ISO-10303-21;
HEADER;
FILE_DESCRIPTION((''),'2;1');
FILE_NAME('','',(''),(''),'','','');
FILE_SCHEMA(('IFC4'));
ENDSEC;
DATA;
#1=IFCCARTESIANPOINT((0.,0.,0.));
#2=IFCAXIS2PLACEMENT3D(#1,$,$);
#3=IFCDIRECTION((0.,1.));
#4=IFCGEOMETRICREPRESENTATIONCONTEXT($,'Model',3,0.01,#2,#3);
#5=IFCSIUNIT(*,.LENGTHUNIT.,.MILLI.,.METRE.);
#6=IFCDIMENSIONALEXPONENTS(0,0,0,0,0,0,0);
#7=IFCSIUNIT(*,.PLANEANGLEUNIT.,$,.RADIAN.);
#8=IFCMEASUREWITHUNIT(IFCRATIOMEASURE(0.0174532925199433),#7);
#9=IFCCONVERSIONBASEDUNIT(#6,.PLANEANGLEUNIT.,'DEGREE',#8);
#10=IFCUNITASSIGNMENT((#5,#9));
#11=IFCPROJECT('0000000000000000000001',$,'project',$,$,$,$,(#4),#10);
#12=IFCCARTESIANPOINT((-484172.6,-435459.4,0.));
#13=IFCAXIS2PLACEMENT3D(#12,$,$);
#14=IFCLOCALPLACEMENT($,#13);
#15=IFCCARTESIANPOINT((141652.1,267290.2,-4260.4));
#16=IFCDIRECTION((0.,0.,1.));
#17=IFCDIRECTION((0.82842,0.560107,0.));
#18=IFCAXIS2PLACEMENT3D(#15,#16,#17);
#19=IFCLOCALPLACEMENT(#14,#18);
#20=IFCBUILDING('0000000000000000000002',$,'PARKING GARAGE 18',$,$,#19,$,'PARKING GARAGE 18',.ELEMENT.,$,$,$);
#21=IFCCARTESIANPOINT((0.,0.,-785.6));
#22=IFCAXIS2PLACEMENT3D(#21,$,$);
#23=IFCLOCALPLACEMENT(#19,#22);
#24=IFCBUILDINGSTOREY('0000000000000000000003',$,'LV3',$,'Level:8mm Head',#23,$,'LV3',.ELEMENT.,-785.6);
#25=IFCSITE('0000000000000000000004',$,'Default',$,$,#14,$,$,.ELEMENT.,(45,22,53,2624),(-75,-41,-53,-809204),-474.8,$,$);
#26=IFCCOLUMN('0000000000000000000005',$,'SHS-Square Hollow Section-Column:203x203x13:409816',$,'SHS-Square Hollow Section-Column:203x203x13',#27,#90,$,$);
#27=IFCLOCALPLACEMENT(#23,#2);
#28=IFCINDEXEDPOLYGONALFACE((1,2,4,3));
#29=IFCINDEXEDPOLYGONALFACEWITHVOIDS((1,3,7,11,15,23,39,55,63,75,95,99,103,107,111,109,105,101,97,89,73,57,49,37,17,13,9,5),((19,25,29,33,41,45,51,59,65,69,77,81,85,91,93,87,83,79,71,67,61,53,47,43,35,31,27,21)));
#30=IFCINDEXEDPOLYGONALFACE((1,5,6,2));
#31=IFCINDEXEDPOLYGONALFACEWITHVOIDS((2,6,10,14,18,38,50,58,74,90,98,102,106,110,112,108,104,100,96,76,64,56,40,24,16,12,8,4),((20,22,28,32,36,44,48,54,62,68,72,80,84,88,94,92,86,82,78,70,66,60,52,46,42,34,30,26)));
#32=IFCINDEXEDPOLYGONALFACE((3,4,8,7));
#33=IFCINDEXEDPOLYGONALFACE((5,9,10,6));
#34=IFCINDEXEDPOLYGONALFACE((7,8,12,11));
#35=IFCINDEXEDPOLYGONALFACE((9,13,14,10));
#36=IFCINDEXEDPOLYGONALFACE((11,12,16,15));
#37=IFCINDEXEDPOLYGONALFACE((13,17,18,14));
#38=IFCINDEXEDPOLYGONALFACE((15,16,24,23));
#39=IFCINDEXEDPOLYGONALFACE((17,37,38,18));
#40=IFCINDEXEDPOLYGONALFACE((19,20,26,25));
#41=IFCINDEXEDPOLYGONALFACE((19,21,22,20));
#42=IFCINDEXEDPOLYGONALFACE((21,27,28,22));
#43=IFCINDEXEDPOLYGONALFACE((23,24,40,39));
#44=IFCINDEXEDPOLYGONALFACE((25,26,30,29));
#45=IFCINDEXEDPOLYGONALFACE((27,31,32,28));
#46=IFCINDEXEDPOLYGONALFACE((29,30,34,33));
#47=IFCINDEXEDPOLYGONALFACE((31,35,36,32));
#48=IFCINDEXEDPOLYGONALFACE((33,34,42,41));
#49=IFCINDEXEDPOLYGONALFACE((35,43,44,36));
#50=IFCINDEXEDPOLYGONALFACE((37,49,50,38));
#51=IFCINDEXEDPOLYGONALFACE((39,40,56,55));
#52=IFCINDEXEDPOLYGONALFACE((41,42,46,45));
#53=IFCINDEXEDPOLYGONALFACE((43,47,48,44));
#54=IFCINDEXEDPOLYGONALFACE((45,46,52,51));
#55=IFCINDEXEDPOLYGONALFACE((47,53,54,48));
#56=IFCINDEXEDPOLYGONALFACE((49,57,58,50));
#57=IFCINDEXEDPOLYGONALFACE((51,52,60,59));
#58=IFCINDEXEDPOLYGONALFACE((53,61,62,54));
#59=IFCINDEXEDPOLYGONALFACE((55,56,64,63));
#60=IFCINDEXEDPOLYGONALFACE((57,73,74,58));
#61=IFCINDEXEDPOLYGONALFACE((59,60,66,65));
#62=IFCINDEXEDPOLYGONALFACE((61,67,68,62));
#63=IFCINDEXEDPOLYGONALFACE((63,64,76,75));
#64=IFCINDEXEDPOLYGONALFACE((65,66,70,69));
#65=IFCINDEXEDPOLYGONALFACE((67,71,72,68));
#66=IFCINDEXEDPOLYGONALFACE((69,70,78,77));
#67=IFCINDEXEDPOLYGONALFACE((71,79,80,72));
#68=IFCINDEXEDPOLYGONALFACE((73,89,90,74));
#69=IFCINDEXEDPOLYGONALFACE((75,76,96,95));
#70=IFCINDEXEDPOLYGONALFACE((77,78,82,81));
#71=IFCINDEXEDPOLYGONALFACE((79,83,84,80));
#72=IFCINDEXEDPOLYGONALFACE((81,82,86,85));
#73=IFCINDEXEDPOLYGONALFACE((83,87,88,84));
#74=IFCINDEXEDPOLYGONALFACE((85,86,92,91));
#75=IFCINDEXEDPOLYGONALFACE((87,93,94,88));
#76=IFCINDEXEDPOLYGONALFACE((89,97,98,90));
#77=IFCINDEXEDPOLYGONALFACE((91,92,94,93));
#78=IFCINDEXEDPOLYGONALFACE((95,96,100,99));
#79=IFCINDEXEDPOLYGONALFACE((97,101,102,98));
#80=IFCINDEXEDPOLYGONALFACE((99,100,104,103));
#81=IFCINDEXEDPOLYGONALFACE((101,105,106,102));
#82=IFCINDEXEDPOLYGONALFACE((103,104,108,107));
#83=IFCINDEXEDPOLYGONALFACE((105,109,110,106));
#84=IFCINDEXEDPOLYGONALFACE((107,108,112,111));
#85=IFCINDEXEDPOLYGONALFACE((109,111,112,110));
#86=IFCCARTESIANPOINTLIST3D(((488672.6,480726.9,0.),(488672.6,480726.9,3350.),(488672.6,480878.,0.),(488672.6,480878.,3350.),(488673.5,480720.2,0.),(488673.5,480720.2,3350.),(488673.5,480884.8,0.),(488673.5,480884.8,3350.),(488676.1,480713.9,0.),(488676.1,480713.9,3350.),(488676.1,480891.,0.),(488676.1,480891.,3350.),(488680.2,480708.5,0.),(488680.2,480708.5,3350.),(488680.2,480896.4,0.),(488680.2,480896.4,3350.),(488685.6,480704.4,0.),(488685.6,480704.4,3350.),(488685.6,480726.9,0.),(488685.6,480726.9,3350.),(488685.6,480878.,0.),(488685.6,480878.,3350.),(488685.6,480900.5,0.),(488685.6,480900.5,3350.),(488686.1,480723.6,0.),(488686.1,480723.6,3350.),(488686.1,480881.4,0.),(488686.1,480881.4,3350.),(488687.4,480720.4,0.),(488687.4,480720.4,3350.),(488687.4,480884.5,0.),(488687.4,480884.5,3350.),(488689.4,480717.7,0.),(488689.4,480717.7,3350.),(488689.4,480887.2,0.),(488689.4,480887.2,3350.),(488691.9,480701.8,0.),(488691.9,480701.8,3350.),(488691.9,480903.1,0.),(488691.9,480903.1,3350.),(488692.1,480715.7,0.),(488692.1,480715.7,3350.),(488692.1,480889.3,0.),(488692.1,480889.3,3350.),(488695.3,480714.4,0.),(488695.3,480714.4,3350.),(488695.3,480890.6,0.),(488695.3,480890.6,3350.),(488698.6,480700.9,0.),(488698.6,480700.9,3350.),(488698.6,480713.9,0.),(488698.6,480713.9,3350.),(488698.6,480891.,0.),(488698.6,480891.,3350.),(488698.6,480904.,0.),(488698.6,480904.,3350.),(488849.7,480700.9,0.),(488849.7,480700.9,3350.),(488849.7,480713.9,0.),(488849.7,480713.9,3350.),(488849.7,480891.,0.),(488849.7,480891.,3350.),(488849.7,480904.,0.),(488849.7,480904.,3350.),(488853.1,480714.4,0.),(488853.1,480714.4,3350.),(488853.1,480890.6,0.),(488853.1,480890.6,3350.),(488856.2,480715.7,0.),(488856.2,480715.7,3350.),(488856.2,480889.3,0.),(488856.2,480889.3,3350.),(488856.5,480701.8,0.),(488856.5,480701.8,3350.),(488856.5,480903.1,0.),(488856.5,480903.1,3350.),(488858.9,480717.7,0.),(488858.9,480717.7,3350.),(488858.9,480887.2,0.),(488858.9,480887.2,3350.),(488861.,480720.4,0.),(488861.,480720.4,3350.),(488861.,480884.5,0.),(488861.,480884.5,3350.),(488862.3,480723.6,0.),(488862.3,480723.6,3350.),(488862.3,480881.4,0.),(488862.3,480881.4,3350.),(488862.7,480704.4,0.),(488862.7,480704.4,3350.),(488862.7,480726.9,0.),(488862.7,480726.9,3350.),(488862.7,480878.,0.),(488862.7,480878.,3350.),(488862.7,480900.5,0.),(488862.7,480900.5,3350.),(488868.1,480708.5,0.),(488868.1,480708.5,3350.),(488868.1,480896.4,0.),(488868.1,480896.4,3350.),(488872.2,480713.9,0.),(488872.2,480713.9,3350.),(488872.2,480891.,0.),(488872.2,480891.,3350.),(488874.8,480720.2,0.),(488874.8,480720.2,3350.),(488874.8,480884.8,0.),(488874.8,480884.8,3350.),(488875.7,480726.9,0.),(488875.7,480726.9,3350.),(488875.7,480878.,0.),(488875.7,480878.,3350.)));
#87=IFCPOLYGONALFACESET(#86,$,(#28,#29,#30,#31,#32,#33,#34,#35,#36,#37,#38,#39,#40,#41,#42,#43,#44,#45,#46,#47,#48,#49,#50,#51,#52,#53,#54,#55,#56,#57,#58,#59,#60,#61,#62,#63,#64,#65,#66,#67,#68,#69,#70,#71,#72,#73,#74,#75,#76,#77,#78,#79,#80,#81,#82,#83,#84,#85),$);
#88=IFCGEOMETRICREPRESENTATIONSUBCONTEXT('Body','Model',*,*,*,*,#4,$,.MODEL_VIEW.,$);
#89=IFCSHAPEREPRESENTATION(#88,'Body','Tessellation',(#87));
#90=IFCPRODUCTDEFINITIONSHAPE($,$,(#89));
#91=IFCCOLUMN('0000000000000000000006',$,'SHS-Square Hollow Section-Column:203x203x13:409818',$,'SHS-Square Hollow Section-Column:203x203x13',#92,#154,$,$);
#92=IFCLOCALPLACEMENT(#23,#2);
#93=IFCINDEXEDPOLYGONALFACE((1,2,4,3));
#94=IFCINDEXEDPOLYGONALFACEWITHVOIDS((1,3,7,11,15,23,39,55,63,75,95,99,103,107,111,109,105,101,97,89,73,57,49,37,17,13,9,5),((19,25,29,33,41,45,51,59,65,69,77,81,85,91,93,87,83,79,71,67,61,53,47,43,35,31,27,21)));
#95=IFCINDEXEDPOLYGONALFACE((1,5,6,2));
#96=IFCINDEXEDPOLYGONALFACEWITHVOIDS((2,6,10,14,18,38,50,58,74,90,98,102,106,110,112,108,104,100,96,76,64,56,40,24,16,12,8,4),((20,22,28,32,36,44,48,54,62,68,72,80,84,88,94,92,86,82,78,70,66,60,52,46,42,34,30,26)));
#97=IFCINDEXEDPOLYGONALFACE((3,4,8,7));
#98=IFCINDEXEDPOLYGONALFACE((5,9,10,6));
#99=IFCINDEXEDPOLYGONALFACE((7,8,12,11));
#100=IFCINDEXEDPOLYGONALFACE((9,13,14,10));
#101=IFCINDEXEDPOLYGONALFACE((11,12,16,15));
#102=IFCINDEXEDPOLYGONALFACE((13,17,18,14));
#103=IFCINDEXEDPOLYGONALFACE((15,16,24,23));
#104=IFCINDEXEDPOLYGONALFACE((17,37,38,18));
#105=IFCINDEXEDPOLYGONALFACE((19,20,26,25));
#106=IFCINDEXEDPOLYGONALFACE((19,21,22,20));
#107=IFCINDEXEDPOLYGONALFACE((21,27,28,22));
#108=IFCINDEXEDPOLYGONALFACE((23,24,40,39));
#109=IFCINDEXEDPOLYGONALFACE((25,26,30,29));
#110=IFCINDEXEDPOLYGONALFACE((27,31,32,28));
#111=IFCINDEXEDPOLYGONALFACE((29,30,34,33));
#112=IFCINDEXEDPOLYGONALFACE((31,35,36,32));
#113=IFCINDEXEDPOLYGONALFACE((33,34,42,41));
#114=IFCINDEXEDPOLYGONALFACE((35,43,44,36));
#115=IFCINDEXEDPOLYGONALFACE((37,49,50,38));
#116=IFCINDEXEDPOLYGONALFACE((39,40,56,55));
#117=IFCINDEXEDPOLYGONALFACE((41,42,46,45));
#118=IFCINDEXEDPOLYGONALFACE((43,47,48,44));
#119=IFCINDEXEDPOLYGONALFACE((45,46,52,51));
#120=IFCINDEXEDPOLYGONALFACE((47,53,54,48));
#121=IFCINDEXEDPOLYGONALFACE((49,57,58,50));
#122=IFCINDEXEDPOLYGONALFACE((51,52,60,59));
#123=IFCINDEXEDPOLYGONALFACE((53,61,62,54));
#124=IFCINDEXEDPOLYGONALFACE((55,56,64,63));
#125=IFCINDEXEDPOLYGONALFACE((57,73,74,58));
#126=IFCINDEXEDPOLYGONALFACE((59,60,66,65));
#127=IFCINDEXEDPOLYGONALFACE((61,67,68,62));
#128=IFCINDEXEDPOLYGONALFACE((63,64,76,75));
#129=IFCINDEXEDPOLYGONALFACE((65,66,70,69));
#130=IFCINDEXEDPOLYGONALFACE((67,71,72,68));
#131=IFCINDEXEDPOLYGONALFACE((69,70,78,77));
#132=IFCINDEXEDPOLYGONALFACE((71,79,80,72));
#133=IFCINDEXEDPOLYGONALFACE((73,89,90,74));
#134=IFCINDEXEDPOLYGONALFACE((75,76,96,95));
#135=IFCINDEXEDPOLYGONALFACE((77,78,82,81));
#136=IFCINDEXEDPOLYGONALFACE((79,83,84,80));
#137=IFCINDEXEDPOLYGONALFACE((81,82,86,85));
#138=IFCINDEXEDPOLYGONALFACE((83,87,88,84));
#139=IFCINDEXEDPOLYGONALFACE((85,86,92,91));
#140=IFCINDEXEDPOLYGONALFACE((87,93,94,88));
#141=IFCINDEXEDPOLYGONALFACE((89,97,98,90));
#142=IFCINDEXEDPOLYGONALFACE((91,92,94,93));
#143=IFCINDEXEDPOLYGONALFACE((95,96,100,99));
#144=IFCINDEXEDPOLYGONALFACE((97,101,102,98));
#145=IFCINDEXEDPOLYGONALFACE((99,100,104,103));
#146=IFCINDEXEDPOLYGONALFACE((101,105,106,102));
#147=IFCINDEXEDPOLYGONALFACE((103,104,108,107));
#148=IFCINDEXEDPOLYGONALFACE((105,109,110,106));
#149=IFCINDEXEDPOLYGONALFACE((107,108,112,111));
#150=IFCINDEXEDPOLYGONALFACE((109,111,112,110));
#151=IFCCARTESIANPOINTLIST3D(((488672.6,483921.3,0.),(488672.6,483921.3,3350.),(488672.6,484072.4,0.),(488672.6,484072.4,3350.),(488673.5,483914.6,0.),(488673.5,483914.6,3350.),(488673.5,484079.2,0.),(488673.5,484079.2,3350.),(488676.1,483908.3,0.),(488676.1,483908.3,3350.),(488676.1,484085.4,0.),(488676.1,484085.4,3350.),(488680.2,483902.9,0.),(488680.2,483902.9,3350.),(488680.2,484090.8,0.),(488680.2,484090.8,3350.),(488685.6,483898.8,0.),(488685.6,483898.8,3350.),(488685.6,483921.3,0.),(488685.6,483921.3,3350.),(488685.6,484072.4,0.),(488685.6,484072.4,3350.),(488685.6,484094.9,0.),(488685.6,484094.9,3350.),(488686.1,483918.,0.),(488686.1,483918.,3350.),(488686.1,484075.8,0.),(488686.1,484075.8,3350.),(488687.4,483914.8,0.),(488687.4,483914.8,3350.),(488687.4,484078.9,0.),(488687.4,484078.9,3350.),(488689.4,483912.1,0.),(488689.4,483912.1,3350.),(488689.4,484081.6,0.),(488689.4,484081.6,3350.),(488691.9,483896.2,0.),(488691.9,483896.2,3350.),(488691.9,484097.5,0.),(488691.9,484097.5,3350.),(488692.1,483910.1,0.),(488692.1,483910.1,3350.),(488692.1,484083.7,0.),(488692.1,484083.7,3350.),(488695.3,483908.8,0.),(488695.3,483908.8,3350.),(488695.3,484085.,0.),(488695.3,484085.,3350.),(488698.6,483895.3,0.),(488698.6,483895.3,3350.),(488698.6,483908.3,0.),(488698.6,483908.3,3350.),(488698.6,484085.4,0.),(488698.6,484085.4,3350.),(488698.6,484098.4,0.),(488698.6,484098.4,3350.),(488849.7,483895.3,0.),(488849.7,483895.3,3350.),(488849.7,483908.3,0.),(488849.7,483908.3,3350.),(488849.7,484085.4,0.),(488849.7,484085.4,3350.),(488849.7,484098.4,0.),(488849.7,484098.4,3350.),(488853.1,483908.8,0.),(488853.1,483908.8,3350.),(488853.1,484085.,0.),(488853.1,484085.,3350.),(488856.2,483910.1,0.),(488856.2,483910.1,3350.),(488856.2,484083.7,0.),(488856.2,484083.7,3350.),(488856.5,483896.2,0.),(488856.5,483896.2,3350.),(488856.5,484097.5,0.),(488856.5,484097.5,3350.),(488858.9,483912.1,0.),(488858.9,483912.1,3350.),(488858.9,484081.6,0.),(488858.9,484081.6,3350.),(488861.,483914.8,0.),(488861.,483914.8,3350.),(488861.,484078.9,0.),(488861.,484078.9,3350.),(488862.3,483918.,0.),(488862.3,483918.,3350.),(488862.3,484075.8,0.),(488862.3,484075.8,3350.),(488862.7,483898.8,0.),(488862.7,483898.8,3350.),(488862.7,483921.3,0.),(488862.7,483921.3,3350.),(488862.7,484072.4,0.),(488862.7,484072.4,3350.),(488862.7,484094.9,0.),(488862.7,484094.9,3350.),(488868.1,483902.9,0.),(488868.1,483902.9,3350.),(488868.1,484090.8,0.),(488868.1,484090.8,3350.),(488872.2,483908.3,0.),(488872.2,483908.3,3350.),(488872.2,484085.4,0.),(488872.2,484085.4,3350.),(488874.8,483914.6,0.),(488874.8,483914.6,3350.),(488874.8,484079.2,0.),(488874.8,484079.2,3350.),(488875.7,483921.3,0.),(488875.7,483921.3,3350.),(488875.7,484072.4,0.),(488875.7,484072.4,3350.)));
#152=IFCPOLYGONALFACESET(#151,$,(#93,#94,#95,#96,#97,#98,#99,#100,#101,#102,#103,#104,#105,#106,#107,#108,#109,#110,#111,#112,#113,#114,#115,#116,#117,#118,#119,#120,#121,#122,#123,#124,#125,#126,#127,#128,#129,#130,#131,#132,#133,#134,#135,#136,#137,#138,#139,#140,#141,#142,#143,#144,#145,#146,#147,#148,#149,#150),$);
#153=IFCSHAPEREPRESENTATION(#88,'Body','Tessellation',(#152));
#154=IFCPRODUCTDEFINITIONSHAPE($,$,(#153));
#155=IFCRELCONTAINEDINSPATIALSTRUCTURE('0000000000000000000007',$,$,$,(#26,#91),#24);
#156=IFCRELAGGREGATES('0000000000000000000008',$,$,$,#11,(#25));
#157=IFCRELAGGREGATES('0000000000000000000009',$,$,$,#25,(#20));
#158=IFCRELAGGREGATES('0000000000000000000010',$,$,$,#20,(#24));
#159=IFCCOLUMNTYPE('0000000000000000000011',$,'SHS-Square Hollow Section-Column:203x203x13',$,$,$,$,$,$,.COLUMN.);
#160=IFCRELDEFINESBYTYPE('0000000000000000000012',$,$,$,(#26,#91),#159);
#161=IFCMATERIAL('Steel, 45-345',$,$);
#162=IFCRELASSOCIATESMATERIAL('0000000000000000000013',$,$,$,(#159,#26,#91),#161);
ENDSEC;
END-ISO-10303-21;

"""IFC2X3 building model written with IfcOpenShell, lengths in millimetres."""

from ifc_helpers import new_model, entity, si_unit, converted_unit, direction, frame, frame_2d, origin, place, context, subcontext, project, spatial, polyline, circle_curve, parameter, trimmed, segment, composite_curve, outline, extrude, source, transform, mapped, material, type_object, type_shapes, element, save


model = new_model("IFC2X3")

# Units and contexts
model_context = context("Model", 3, precision=0.01, world=origin(), true_north=direction((0.0, 1.0)))
body_context = subcontext(model_context, "Body", "Model", "MODEL_VIEW")
ifc_project = project(units=[si_unit("LENGTHUNIT", "METRE", prefix="MILLI"), converted_unit("PLANEANGLEUNIT", "DEGREE", entity("IfcRatioMeasure", 0.0174532925199433), si_unit("PLANEANGLEUNIT", "RADIAN"), dimensions=[0, 0, 0, 0, 0, 0, 0])], contexts=[model_context])

# Site, building, storey
site_placement = place(None, frame((-484172.6, -435459.4, 0.0)))
site = spatial("IfcSite", under=ifc_project, at=site_placement, Name="Default", CompositionType="ELEMENT", RefLatitude=(45, 22, 53, 2624), RefLongitude=(-75, -41, -53, -809204), RefElevation=-474.8)
building_placement = place(site_placement, frame((141652.1, 267290.2, -4260.4), z_axis=(0.0, 0.0, 1.0), x_axis=(0.82842, 0.560107, 0.0)))
building = spatial("IfcBuilding", under=site, at=building_placement, Name="PARKING GARAGE 18", LongName="PARKING GARAGE 18", CompositionType="ELEMENT")
storey_placement = place(building_placement, frame((0.0, 0.0, -785.6)))
storey = spatial("IfcBuildingStorey", under=building, at=storey_placement, Name="LV3", ObjectType="Level:8mm Head", LongName="LV3", CompositionType="ELEMENT", Elevation=-785.6)

# Columns
ifc_material_1 = material(Name="Steel, 45-345")
column_type_1 = type_object("IfcColumnType", Name="SHS-Square Hollow Section-Column:203x203x13", PredefinedType="COLUMN", material=ifc_material_1)
shared_shape_1 = source(origin(), body_context, "Body", "SweptSolid", [
    extrude(outline(composite_curve([segment(polyline([(-75.6, -101.5), (75.6, -101.5)]), True, "CONTINUOUS"), segment(trimmed(circle_curve(frame_2d((75.6, -75.6), x_axis=(-1.0, 0.0)), 26.0), [parameter(90.0)], [parameter(180.0)], True, "PARAMETER"), True, "CONTINUOUS"), segment(polyline([(101.5, -75.6), (101.5, 75.6)]), True, "CONTINUOUS"), segment(trimmed(circle_curve(frame_2d((75.5, 75.6), x_axis=(-1.0, 0.0)), 26.0), [parameter(180.0)], [parameter(270.0)], True, "PARAMETER"), True, "CONTINUOUS"), segment(polyline([(75.5, 101.6), (-75.5, 101.6)]), True, "CONTINUOUS"), segment(trimmed(circle_curve(frame_2d((-75.5, 75.5), x_axis=(-1.0, 0.0)), 26.0), [parameter(270.0)], [parameter(360.0)], True, "PARAMETER"), True, "CONTINUOUS"), segment(polyline([(-101.5, 75.5), (-101.5, -75.6)]), True, "CONTINUOUS"), segment(trimmed(circle_curve(frame_2d((-75.6, -75.6), x_axis=(-1.0, 0.0)), 26.0), [parameter(360.0)], [parameter(90.0)], True, "PARAMETER"), True, "CONTINUOUS")], self_intersect=False), holes=[composite_curve([segment(trimmed(circle_curve(frame_2d((-75.6, -75.6), x_axis=(-1.0, 0.0)), 13.0), [parameter(0.0)], [parameter(90.0)], True, "PARAMETER"), False, "CONTINUOUS"), segment(polyline([(-88.5, -75.6), (-88.5, 75.6)]), True, "CONTINUOUS"), segment(trimmed(circle_curve(frame_2d((-75.6, 75.6), x_axis=(-1.0, 0.0)), 13.0), [parameter(270.0)], [parameter(0.0)], True, "PARAMETER"), False, "CONTINUOUS"), segment(polyline([(-75.6, 88.6), (75.5, 88.6)]), True, "CONTINUOUS"), segment(trimmed(circle_curve(frame_2d((75.5, 75.5), x_axis=(-1.0, 0.0)), 13.0), [parameter(180.0)], [parameter(270.0)], True, "PARAMETER"), False, "CONTINUOUS"), segment(polyline([(88.6, 75.5), (88.6, -75.5)]), True, "CONTINUOUS"), segment(trimmed(circle_curve(frame_2d((75.6, -75.5), x_axis=(-1.0, 0.0)), 13.0), [parameter(90.0)], [parameter(180.0)], True, "PARAMETER"), False, "CONTINUOUS"), segment(polyline([(75.6, -88.5), (-75.6, -88.5)]), True, "CONTINUOUS")], self_intersect=False)]), frame((0.0, 0.0, -785.6), z_axis=(0.0, 0.0, 1.0), x_axis=(-1.0, 0.0, 0.0)), (0.0, 0.0, 1.0), 3350.0),
])
type_shapes(column_type_1, [shared_shape_1])
for number, where, name in (
    (1, (488774.2, 480802.5, 785.6), "SHS-Square Hollow Section-Column:203x203x13:409816"),
    (2, (488774.2, 483996.9, 785.6), "SHS-Square Hollow Section-Column:203x203x13:409818"),
):
    element("IfcColumn", number, at=place(storey_placement, frame(where)), inside=storey, type_object=column_type_1, material=ifc_material_1, Name=name, ObjectType="SHS-Square Hollow Section-Column:203x203x13", context=body_context, shape_type="MappedRepresentation", body=[
        mapped(shared_shape_1, transform((0.0, 0.0, 0.0), scale=1.0)),
    ])

save(model, "model.ifc")
